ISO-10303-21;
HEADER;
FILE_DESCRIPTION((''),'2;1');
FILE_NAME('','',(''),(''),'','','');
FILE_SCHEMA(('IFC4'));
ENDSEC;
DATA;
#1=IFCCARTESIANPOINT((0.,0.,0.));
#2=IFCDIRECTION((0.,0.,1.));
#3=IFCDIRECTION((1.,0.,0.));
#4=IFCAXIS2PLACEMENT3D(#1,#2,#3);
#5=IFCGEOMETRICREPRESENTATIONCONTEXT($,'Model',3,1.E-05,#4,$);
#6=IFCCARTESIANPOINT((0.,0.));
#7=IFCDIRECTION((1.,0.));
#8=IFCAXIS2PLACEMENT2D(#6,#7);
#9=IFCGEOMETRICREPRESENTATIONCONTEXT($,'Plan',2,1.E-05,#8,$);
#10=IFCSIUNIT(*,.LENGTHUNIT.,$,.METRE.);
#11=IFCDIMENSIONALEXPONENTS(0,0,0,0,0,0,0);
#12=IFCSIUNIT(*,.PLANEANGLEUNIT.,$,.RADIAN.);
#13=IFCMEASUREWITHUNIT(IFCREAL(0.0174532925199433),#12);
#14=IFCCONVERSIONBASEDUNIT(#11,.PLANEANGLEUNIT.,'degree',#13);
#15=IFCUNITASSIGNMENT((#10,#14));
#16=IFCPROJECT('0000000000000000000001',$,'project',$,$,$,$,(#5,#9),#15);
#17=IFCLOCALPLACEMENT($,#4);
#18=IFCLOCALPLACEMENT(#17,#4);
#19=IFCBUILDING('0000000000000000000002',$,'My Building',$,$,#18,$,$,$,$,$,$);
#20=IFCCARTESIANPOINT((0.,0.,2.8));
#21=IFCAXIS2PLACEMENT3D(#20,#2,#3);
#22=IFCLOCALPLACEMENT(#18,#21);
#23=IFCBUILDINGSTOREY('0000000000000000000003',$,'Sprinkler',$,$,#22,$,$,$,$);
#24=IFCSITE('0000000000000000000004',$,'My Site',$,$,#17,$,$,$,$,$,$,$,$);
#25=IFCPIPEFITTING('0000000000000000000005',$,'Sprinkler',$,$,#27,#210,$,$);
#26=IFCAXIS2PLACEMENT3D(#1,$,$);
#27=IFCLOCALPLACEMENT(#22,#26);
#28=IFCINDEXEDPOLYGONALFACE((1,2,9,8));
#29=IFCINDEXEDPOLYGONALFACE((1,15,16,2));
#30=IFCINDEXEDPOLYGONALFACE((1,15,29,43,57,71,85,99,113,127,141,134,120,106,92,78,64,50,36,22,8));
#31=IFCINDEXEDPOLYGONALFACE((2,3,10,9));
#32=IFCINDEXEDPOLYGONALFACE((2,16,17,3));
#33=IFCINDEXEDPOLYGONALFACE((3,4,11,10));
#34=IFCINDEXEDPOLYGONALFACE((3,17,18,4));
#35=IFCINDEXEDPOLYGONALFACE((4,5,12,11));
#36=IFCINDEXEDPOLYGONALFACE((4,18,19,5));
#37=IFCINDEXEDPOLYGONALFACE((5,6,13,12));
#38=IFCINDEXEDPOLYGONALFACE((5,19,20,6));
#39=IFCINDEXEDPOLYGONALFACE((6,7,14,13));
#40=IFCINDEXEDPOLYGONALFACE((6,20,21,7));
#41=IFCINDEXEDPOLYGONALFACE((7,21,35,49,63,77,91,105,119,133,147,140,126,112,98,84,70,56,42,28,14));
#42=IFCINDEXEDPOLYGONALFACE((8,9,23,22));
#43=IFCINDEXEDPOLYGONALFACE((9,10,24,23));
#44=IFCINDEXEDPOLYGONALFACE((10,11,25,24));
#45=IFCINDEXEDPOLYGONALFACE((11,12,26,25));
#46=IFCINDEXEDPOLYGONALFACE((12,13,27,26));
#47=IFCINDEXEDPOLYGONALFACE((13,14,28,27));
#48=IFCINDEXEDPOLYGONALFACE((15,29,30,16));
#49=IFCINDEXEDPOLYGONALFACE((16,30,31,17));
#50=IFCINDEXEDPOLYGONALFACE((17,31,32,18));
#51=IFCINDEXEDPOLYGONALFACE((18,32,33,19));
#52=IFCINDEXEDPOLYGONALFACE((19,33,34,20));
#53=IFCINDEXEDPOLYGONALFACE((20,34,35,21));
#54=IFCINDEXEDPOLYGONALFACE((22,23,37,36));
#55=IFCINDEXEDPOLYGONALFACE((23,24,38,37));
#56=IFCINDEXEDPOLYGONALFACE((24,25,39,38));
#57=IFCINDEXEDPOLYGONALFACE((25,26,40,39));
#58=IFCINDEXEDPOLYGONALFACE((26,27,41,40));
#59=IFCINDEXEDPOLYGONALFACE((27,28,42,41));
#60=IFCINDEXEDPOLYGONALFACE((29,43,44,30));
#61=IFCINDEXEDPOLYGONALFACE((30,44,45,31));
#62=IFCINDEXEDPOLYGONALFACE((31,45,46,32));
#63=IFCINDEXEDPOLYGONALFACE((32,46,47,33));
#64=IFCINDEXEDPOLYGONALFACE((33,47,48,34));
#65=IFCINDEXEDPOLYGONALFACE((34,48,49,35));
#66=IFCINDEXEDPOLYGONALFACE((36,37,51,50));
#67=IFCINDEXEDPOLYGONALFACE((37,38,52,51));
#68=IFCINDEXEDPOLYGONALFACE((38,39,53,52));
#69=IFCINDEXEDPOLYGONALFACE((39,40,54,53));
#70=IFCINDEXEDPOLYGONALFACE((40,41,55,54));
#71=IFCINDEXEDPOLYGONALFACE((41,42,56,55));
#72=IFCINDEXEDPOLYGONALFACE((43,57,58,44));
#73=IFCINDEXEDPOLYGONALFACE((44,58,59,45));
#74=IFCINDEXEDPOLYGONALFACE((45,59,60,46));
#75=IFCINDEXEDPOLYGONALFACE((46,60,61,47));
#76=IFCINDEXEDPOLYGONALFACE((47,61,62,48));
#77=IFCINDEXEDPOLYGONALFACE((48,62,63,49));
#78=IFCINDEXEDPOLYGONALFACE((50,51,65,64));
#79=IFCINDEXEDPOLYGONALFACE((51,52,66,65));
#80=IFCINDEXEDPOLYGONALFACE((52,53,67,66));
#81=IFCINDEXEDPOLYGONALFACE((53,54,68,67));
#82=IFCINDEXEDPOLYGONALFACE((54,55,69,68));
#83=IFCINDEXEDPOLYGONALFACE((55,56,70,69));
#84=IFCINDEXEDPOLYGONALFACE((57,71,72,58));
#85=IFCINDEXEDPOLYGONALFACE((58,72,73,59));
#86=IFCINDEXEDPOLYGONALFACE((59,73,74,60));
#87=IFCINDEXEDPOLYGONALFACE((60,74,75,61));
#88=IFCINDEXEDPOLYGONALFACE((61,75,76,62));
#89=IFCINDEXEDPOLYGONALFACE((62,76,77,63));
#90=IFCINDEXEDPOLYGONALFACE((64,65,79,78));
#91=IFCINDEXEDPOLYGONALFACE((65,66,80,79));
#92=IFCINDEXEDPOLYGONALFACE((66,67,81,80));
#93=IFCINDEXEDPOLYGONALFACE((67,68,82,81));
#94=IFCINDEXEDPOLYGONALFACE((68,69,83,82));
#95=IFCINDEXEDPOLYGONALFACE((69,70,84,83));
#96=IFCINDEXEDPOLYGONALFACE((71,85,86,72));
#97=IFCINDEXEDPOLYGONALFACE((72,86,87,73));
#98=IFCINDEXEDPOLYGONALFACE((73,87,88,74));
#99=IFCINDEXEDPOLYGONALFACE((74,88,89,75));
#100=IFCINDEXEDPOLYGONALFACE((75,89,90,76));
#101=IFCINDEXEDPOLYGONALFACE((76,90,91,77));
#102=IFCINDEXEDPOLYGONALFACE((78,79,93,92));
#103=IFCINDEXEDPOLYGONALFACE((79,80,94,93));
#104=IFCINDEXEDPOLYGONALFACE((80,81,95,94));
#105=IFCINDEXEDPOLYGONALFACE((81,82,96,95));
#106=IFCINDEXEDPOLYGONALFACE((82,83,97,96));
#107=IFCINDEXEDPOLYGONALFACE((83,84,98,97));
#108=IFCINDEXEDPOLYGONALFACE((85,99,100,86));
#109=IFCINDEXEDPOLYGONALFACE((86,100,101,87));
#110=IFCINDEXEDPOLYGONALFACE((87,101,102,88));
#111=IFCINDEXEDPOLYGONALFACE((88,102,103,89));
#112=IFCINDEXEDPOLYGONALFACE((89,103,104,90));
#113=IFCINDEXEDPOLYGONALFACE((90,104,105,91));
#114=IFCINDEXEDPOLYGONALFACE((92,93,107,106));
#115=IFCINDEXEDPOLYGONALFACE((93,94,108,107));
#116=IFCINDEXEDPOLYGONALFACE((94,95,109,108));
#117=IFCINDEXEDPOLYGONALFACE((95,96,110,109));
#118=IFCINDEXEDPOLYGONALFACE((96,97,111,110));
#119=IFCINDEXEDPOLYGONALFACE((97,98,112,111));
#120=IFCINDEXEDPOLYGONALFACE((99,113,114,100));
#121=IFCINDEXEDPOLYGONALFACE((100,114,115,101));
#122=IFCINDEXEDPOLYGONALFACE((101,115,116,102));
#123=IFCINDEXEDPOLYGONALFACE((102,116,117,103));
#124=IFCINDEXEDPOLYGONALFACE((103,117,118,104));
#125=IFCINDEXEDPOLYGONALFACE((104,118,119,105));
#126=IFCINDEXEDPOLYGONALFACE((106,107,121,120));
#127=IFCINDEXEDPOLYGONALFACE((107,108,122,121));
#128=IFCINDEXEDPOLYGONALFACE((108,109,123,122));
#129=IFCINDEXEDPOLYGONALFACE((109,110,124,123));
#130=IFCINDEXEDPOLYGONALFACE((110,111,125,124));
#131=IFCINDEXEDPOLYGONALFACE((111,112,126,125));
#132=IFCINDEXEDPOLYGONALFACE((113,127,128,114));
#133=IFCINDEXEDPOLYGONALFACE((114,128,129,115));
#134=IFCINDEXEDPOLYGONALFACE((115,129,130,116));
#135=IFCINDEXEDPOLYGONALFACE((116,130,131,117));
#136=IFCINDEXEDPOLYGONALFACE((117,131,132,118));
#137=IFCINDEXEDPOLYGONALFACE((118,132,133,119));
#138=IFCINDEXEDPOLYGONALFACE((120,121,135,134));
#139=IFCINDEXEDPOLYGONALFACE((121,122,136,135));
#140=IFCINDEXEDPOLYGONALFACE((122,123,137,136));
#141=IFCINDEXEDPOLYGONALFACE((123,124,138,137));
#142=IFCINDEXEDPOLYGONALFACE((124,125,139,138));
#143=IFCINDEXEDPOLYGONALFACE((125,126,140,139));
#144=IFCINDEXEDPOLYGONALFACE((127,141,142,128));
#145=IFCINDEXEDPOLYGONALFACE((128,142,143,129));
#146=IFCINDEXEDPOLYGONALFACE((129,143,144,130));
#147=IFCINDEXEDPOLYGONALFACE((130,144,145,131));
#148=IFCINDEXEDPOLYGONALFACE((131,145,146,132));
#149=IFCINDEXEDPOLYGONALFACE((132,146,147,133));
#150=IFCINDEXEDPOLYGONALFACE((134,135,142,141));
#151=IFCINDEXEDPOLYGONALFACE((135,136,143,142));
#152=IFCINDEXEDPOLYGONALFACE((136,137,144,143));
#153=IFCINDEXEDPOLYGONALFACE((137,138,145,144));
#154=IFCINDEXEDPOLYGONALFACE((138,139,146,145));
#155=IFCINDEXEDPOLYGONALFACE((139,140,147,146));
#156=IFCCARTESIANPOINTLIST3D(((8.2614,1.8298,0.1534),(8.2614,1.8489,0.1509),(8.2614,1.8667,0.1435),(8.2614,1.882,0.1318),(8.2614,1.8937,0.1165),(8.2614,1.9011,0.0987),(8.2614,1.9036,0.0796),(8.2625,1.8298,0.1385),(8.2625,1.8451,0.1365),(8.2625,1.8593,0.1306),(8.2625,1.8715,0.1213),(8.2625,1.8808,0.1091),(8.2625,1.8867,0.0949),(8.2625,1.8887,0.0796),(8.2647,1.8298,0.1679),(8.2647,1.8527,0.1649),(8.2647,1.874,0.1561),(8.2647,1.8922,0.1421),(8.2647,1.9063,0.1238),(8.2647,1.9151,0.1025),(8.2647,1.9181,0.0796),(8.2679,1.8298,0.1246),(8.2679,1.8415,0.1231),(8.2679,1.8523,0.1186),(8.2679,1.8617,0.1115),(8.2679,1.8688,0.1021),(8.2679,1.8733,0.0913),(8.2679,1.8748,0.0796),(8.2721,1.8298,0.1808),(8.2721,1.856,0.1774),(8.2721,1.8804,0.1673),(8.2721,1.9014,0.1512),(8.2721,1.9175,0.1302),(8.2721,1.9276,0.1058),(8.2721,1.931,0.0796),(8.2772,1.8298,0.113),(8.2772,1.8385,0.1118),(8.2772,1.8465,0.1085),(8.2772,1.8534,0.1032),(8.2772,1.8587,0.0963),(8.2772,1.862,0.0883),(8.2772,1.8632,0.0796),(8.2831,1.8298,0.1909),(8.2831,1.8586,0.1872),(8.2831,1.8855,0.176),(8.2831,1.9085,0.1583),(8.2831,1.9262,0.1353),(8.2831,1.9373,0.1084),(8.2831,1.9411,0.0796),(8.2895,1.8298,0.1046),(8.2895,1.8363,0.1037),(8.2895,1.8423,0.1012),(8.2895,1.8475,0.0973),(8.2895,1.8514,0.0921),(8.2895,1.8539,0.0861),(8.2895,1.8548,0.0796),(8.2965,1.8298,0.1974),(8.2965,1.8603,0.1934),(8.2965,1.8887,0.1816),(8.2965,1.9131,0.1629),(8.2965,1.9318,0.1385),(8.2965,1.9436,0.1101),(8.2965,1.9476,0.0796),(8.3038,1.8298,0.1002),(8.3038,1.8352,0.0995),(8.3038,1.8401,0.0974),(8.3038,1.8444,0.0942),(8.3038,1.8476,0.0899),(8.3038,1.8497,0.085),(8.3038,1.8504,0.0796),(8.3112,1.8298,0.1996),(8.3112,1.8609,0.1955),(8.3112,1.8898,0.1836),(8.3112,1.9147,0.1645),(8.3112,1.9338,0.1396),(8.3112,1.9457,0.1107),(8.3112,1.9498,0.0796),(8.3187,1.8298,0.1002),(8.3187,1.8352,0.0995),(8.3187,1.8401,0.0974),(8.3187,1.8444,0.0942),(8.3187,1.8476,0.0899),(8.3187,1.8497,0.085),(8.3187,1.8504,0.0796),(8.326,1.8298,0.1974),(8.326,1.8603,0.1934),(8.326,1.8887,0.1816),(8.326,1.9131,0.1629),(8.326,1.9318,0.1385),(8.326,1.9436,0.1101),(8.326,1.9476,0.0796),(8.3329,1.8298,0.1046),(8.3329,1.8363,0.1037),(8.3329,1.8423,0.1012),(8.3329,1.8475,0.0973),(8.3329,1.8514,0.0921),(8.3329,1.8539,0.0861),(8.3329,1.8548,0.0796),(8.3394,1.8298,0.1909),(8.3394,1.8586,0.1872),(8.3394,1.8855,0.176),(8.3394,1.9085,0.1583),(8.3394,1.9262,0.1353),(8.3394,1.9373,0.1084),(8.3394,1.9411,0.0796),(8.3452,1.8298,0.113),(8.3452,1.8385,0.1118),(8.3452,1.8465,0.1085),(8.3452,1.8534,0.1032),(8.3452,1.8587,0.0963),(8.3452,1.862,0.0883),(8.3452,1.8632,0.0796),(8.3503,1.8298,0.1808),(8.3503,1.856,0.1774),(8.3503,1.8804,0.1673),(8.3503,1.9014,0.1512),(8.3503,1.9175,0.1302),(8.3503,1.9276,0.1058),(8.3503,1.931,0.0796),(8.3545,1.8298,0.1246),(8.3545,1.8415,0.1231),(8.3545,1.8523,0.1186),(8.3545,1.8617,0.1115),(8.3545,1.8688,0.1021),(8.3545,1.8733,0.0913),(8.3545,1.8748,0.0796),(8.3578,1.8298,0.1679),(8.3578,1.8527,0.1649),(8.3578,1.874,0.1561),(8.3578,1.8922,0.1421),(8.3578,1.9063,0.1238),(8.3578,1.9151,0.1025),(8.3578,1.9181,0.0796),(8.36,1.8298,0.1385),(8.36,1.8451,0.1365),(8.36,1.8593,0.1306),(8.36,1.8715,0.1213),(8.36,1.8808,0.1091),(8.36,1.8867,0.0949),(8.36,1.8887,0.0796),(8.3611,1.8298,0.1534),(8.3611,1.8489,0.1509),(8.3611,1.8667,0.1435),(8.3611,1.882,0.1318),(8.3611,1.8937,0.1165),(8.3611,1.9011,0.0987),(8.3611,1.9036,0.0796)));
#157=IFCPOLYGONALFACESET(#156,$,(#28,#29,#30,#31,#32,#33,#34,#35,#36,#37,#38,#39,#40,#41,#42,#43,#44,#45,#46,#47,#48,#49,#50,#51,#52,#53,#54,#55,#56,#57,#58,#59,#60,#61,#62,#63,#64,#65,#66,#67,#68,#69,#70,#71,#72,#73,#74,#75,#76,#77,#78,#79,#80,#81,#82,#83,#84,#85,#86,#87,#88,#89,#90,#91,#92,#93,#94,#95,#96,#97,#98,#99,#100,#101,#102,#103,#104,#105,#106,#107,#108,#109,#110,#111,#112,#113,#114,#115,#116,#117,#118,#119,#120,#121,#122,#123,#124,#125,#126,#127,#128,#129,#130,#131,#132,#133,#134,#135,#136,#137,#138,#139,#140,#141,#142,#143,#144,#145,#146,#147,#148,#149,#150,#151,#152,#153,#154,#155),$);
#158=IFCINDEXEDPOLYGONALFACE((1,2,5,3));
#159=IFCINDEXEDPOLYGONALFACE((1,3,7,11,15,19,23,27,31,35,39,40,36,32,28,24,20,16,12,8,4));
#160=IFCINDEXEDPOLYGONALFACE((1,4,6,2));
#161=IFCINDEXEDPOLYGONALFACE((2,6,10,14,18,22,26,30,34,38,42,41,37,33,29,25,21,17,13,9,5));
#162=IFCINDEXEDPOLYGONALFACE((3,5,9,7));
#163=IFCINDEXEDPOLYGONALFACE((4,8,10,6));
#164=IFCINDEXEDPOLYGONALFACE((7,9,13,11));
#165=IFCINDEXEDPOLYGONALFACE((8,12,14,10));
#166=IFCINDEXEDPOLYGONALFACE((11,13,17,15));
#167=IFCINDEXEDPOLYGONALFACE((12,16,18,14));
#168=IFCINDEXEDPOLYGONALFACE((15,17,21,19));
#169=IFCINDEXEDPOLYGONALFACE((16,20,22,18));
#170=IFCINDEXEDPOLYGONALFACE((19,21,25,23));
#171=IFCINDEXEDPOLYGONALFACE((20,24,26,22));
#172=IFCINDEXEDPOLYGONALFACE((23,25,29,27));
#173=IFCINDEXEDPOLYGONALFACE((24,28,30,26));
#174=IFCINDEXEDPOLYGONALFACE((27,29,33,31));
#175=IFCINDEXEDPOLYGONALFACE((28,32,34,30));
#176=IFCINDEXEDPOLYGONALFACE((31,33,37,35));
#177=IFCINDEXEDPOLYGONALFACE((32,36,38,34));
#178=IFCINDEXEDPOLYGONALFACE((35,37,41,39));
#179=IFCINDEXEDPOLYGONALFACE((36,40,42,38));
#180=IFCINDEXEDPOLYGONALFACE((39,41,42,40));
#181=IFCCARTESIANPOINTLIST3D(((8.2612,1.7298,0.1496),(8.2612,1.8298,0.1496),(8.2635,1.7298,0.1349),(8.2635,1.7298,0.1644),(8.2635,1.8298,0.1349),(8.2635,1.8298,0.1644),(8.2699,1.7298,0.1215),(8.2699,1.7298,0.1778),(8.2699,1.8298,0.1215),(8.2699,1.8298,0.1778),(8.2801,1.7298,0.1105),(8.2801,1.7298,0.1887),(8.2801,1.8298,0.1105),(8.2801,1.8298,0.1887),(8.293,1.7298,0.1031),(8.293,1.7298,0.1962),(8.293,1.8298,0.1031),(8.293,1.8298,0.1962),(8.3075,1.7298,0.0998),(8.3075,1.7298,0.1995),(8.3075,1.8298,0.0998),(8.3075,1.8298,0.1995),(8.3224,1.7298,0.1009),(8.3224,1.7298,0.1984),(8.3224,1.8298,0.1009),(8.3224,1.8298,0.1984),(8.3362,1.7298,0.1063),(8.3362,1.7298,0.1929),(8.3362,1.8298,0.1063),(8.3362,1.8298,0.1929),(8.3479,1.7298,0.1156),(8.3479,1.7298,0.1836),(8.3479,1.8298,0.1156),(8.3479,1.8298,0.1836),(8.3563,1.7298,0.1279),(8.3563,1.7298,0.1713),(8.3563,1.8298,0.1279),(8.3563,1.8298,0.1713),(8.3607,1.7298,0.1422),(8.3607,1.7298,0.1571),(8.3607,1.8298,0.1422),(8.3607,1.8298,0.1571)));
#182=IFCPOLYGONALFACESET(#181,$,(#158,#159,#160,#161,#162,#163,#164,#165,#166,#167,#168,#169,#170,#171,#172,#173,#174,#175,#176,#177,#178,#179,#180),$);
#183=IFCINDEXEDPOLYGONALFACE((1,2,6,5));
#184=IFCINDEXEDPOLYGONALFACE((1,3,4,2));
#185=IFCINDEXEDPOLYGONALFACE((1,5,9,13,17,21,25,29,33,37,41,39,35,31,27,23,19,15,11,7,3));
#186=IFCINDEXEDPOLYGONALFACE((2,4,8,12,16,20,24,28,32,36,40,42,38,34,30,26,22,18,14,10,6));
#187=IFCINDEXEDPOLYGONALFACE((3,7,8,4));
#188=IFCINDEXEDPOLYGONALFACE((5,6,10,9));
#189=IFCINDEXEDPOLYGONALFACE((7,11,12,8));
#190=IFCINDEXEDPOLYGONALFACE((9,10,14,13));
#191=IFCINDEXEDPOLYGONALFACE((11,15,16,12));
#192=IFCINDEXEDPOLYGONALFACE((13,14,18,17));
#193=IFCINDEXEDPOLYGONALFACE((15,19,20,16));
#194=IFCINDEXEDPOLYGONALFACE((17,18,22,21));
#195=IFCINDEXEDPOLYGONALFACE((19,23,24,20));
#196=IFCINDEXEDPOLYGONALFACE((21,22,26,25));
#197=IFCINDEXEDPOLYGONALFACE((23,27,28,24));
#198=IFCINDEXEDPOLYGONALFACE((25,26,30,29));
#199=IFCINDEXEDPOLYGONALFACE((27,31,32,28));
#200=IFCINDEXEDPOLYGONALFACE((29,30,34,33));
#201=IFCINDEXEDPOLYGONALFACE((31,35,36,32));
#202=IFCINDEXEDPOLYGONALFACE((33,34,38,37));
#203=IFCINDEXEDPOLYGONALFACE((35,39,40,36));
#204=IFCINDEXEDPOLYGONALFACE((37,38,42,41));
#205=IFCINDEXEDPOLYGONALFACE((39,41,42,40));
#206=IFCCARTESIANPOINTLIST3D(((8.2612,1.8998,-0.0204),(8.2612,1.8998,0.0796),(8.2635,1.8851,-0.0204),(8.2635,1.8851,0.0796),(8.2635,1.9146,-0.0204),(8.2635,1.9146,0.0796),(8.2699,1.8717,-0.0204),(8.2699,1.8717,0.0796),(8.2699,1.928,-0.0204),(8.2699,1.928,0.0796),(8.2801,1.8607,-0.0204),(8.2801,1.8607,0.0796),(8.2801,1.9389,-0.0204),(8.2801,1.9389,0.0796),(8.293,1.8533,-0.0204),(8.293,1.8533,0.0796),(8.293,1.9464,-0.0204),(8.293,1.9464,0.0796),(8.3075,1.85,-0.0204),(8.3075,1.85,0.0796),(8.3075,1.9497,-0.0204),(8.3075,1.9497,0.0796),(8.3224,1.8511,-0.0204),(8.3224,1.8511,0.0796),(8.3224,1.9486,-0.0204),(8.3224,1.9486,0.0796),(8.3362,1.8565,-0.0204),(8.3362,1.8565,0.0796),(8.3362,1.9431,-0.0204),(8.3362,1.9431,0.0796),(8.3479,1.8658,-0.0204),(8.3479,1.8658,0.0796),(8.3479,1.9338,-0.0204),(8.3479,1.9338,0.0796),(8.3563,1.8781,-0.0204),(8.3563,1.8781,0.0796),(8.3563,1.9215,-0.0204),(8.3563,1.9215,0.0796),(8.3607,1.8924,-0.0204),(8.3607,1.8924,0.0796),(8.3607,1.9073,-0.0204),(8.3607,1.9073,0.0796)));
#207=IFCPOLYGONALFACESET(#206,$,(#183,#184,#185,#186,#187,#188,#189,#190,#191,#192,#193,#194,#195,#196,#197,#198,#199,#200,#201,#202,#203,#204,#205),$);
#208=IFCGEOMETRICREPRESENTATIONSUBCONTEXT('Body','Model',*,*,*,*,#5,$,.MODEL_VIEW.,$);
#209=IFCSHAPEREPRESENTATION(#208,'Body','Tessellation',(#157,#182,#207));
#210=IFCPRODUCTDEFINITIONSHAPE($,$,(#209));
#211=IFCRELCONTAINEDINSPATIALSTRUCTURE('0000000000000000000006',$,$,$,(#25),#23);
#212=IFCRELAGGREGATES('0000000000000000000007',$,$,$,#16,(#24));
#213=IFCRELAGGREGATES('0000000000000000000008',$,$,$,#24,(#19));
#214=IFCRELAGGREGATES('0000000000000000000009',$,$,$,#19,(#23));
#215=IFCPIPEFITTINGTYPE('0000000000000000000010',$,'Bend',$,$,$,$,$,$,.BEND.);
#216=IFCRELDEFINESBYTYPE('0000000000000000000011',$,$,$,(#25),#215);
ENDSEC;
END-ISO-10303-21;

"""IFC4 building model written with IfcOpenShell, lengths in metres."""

from ifc_helpers import new_model, entity, si_unit, converted_unit, frame, origin_with_axes, origin_2d_with_axis, place, context, subcontext, project, spatial, circle, extrude, source, transform, mapped, type_object, type_shapes, element, save


model = new_model("IFC4")

# Units and contexts
model_context = context("Model", 3, precision=1e-05, world=origin_with_axes())
plan_context = context("Plan", 2, precision=1e-05, world=origin_2d_with_axis())
body_context = subcontext(model_context, "Body", "Model", "MODEL_VIEW")
ifc_project = project(units=[si_unit("LENGTHUNIT", "METRE"), converted_unit("PLANEANGLEUNIT", "degree", entity("IfcReal", 0.0174532925199433), si_unit("PLANEANGLEUNIT", "RADIAN"), dimensions=[0, 0, 0, 0, 0, 0, 0])], contexts=[model_context, plan_context])

# Site, building, storey
site_placement = place(None, origin_with_axes())
site = spatial("IfcSite", under=ifc_project, at=site_placement, Name="My Site")
building_placement = place(site_placement, origin_with_axes())
building = spatial("IfcBuilding", under=site, at=building_placement, Name="My Building")
storey_placement = place(building_placement, frame((0.0, 0.0, 2.8), z_axis=(0.0, 0.0, 1.0), x_axis=(1.0, 0.0, 0.0)))
storey = spatial("IfcBuildingStorey", under=building, at=storey_placement, Name="Sprinkler")

# Pipe fitting
pipe_fitting_type_1 = type_object("IfcPipeFittingType", Name="Bend", PredefinedType="BEND")
shared_shape_1 = source(origin_with_axes(), body_context, "Body", "SolidModel", [
    entity("IfcSweptDiskSolid", entity("IfcIndexedPolyCurve", entity("IfcCartesianPointList3D", [[0.0, 0.0, 0.1], [0.0, -0.0205, 0.1495], [0.0, -0.07, 0.17]]), [entity("IfcArcIndex", [1, 2, 3])]), 0.05),
    extrude(circle(Radius=0.05), origin_with_axes(), (0.0, 0.0, 1.0), 0.1),
    extrude(circle(Radius=0.05), frame((0.0, -0.07, 0.17), z_axis=(0.0, -1.0, 0.0), x_axis=(1.0, 0.0, 0.0)), (0.0, 0.0, 1.0), 0.1),
])
type_shapes(pipe_fitting_type_1, [shared_shape_1])
for number, where, z_axis, x_axis, name in (
    (1, (8.3112, 1.7298, 0.1496), (-0.000001, 1.0, 0.0), (-1.0, -0.000001, 0.0), "Sprinkler"),
):
    element("IfcPipeFitting", number, at=place(storey_placement, frame(where, z_axis=z_axis, x_axis=x_axis)), inside=storey, type_object=pipe_fitting_type_1, Name=name, context=body_context, shape_type="MappedRepresentation", body=[
        mapped(shared_shape_1, transform((0.0, 0.0, 0.0), x_axis=(1.0, 0.0, 0.0), y_axis=(0.0, 1.0, 0.0), z_axis=(0.0, 0.0, 1.0), scale=1.0)),
    ])

save(model, "model.ifc")
